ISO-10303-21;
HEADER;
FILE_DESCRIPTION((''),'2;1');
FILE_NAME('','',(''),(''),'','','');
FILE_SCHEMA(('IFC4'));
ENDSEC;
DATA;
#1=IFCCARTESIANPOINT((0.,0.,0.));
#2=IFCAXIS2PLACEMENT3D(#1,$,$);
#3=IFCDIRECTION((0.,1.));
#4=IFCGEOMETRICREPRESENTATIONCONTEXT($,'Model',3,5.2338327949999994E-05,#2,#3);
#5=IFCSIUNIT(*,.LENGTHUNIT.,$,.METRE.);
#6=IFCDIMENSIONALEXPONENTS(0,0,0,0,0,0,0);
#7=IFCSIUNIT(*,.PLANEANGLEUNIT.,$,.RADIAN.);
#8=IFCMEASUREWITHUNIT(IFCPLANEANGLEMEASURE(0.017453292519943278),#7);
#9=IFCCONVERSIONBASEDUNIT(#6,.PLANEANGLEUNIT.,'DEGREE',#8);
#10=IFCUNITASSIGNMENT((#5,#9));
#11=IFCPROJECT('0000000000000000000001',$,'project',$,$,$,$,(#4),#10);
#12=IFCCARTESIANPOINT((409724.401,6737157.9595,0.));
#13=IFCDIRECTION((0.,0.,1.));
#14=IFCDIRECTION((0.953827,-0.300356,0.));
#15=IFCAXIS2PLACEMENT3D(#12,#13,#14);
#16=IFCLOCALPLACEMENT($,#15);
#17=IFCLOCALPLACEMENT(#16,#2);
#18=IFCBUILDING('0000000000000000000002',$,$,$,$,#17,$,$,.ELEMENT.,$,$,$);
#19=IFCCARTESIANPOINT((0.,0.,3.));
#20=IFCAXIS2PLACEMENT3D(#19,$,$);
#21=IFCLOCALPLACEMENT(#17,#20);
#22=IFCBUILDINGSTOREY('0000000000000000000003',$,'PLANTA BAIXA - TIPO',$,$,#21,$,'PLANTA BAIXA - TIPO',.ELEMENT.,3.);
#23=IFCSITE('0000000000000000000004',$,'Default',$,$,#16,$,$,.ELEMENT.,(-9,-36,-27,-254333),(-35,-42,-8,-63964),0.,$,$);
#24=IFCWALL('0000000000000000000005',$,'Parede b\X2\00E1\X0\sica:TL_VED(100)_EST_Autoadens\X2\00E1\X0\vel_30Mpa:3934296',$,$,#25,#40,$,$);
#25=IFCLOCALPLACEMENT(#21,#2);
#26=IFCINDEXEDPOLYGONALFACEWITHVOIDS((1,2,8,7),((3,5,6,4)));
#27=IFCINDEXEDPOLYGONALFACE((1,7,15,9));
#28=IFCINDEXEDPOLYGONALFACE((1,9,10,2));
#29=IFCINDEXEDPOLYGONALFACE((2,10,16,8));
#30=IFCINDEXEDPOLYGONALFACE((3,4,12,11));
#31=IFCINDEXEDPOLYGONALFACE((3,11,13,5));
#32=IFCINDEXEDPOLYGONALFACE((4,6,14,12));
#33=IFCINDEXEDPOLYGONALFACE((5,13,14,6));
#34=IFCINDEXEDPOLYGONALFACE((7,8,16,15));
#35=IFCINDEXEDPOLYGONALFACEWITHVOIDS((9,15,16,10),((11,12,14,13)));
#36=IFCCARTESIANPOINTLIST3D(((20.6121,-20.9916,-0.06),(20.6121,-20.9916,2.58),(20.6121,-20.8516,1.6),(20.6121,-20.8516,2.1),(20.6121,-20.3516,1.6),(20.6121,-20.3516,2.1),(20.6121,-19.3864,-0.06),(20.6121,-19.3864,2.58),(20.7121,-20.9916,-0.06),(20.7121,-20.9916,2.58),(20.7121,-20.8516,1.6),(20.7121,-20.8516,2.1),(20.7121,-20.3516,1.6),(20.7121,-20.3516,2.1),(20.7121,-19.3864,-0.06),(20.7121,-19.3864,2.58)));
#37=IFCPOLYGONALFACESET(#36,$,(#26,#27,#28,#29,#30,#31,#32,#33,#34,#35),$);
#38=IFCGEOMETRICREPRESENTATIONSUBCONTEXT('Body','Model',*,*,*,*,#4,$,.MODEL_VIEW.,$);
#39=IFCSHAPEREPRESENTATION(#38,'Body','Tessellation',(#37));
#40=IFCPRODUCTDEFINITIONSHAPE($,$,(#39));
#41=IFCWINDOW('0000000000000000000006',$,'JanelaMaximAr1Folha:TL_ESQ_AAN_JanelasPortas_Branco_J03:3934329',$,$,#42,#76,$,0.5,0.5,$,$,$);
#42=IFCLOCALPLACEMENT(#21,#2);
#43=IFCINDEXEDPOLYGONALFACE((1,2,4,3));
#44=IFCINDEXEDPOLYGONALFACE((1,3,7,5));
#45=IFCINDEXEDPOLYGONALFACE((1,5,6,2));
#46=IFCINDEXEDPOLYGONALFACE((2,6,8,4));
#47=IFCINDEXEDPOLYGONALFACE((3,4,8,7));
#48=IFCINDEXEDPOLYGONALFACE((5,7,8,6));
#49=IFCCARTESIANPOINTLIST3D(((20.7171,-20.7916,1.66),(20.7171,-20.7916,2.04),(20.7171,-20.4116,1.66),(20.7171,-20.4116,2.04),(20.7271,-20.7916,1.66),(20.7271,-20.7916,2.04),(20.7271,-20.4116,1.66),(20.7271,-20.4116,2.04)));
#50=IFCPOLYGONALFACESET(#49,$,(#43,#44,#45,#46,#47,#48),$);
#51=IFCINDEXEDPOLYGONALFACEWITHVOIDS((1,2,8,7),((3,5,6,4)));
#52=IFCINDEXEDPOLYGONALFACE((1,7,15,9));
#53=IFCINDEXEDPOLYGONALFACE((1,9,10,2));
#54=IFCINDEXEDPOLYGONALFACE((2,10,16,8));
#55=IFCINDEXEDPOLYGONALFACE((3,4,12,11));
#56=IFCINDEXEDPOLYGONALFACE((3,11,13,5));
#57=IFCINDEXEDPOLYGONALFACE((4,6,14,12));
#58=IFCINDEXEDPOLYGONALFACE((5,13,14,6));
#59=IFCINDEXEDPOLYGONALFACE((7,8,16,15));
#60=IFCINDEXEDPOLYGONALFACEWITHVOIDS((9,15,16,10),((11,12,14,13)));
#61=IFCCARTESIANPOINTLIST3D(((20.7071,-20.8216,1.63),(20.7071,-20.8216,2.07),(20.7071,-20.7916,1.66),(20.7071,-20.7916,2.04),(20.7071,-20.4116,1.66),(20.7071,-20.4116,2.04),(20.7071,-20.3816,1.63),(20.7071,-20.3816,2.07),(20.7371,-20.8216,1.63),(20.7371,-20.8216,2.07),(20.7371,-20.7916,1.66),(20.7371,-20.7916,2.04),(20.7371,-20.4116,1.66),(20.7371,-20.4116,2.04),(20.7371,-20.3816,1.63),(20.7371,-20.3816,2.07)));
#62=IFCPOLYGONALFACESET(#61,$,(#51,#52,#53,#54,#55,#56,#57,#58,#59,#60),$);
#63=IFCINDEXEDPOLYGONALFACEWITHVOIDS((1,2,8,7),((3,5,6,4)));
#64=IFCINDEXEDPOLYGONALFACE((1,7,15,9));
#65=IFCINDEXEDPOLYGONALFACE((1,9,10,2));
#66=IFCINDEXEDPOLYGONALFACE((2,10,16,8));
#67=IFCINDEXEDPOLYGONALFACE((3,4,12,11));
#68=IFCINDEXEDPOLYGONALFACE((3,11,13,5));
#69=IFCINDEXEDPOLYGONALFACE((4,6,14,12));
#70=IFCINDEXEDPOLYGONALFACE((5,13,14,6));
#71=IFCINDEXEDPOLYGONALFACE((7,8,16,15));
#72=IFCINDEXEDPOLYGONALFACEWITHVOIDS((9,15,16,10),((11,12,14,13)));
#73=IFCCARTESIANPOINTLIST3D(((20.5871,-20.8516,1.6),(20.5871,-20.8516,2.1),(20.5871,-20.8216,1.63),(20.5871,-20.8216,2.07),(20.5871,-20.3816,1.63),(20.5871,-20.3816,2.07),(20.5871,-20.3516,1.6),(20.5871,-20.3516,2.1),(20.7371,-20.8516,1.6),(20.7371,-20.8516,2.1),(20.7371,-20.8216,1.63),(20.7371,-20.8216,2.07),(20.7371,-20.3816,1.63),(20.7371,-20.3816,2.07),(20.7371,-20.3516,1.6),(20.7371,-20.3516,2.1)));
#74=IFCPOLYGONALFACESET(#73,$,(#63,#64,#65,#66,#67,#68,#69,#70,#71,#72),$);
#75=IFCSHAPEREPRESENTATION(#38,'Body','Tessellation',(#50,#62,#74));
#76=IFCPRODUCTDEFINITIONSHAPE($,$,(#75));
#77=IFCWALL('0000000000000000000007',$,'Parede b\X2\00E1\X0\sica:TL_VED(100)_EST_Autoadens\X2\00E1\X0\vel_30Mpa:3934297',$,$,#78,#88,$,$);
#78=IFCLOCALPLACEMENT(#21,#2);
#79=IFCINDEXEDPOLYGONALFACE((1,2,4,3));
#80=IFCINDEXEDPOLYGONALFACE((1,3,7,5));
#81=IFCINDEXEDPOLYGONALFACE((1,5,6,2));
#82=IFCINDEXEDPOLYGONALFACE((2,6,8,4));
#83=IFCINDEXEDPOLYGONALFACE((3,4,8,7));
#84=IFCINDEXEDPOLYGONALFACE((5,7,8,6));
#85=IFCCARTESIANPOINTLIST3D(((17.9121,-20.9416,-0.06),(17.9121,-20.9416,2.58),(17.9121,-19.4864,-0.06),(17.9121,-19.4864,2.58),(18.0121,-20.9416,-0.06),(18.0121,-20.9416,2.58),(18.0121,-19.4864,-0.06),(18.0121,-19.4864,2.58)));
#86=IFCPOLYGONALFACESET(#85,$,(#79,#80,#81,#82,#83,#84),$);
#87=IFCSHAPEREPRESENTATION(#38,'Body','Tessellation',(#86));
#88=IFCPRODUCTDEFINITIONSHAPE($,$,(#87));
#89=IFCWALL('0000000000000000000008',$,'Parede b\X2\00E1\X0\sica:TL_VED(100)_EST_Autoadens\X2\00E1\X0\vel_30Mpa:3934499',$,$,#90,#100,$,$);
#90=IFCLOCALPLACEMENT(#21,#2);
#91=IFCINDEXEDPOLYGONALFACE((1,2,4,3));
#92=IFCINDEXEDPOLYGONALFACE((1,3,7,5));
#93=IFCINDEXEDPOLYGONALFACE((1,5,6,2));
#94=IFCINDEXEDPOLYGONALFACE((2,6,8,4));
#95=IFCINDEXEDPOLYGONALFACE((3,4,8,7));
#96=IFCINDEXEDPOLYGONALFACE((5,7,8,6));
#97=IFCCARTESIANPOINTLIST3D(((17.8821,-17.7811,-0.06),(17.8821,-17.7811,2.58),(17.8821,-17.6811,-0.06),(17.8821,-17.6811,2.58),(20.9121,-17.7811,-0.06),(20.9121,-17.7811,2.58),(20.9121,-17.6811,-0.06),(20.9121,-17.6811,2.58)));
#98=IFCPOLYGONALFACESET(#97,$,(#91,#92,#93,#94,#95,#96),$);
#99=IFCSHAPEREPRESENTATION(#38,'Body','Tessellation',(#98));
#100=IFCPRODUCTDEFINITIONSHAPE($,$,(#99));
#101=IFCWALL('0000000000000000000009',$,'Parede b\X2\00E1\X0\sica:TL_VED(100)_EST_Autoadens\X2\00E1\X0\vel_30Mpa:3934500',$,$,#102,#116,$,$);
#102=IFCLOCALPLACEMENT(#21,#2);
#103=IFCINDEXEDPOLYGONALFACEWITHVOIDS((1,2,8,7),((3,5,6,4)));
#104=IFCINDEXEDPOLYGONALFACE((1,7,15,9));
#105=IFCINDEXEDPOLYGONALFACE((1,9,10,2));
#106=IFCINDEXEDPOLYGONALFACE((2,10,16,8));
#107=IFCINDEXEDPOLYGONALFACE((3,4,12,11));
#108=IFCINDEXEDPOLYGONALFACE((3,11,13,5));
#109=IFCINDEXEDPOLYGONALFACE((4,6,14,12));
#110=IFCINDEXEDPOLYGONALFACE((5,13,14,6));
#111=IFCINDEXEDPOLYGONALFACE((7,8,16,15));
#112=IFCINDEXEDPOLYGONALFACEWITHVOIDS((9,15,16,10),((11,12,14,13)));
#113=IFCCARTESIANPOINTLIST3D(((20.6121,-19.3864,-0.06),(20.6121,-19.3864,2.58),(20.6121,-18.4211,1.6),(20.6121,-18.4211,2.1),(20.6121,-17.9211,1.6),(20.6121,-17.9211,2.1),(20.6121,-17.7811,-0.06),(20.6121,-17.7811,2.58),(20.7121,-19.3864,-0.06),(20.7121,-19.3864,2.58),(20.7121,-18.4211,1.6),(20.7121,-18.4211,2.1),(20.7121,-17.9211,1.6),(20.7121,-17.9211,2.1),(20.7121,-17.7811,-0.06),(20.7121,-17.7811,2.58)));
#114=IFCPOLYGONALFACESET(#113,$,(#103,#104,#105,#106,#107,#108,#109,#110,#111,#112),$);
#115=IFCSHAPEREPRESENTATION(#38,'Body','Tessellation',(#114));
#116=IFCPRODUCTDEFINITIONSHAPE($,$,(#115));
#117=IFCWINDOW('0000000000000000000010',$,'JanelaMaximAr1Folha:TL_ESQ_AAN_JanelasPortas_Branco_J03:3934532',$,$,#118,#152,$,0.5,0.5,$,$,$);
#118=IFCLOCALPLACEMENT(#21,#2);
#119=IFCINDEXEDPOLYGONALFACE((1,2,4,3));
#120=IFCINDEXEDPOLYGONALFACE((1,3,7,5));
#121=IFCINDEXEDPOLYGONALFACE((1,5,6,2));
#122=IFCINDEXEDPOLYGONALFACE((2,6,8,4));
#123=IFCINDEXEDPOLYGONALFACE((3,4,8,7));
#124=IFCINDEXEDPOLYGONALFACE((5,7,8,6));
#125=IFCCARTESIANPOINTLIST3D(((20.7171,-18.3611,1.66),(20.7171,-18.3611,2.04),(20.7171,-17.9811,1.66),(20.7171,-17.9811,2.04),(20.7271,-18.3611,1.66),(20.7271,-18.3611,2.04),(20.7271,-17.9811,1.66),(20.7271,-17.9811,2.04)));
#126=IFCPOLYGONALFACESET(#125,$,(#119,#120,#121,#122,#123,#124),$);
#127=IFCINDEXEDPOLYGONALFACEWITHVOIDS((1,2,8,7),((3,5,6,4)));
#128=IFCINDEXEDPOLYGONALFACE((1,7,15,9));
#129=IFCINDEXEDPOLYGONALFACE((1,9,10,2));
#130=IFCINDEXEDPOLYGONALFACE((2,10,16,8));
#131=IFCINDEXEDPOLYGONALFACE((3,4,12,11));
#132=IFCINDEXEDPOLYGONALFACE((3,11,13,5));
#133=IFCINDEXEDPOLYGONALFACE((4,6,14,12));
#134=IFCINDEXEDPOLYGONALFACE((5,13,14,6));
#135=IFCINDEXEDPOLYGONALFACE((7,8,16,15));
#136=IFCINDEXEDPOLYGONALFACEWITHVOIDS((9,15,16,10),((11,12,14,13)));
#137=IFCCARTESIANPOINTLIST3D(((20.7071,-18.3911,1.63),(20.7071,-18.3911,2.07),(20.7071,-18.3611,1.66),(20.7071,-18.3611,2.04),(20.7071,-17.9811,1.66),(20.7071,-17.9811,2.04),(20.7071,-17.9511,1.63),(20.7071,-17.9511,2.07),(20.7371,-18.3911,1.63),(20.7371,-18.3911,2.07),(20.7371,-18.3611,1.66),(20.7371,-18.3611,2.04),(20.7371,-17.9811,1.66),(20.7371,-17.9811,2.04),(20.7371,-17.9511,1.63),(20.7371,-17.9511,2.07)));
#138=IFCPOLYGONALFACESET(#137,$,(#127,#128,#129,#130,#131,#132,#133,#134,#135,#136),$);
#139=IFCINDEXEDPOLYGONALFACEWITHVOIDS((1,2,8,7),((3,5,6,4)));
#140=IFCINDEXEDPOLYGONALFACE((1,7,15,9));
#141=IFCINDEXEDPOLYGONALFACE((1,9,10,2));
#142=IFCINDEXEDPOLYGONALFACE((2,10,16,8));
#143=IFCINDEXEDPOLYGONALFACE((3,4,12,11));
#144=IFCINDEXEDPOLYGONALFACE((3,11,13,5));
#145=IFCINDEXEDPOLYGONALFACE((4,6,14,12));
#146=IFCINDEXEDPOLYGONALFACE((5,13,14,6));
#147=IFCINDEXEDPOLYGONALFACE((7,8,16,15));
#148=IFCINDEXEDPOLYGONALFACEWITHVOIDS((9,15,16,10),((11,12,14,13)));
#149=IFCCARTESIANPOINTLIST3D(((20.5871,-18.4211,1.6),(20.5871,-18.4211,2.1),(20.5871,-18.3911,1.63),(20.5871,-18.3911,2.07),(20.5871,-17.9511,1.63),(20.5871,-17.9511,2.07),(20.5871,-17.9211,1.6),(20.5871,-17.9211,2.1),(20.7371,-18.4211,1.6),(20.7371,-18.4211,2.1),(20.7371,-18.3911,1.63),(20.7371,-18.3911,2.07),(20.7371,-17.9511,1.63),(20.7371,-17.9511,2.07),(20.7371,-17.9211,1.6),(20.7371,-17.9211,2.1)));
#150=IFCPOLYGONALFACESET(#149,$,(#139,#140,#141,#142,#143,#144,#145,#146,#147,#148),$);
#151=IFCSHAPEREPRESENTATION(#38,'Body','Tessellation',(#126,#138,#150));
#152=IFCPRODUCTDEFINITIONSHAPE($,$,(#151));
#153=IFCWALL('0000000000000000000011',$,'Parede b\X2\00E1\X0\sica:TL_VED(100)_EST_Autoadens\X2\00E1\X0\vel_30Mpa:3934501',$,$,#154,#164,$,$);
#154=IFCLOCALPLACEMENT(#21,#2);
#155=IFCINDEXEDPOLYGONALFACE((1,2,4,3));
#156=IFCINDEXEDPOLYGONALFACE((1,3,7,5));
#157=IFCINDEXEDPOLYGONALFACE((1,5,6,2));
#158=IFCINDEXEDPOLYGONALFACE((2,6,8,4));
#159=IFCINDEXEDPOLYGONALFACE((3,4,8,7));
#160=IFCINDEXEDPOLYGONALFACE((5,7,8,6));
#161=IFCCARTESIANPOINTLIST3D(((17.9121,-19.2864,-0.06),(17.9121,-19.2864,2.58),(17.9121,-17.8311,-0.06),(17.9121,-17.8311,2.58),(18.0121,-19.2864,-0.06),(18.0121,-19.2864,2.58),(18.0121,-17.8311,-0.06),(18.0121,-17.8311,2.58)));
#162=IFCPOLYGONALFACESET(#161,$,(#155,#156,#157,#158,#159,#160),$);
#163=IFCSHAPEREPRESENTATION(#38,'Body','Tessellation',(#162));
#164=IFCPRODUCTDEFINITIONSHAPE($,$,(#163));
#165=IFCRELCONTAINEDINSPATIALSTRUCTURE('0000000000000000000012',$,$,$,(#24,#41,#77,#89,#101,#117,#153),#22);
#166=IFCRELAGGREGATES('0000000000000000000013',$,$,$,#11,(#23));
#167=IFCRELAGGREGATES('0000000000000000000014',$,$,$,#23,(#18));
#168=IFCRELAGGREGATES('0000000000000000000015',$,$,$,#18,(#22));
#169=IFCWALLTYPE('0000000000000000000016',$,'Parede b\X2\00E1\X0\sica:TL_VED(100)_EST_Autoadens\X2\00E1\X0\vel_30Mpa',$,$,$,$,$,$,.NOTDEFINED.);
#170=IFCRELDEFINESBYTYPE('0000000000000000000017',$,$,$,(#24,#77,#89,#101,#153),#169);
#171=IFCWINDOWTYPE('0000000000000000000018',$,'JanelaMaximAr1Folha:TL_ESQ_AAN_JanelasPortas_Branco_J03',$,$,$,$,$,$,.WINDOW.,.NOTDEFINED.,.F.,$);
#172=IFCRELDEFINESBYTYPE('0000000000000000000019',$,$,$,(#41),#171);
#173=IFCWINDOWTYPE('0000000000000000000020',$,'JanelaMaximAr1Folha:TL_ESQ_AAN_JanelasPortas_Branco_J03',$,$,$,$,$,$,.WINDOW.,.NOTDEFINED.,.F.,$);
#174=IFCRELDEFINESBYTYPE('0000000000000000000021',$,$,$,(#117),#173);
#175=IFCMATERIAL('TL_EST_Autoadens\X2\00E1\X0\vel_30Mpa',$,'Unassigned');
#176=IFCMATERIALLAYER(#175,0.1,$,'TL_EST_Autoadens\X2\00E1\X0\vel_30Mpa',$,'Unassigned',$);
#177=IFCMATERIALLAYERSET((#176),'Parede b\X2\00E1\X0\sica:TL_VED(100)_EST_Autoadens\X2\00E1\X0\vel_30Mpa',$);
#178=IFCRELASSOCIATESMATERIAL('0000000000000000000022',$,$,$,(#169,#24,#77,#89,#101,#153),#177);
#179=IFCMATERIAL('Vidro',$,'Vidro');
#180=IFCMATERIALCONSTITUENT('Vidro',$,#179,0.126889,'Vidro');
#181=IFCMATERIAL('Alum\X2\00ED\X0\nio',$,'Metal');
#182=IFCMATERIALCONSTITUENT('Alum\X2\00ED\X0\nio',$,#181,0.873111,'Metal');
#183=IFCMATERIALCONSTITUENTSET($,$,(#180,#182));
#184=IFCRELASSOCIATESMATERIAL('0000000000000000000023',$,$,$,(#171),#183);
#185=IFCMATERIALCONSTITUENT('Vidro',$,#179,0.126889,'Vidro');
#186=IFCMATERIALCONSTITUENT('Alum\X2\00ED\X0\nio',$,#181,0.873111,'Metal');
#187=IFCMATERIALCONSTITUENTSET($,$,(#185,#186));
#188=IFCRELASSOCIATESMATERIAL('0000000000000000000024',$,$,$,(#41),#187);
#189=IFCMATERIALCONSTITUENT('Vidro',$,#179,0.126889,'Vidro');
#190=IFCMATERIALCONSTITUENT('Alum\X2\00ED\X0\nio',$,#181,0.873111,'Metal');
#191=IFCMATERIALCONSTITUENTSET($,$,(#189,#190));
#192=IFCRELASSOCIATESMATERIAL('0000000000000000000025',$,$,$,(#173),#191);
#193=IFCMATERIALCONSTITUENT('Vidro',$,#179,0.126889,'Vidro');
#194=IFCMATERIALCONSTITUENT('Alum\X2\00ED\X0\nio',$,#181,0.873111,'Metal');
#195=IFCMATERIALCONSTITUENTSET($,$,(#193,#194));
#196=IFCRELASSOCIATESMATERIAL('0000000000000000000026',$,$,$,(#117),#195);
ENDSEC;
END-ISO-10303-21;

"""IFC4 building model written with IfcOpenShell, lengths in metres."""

from ifc_helpers import new_model, entity, si_unit, converted_unit, direction, frame, frame_2d, origin, place, context, subcontext, project, spatial, polyline, rectangle, outline, extrude, source, transform, mapped, material, layer, layer_set, layer_usage, constituent, constituent_set, type_object, type_shapes, element, fill, save


model = new_model("IFC4")

# Units and contexts
model_context = context("Model", 3, precision=5.2338327949999994e-05, world=origin(), true_north=direction((0.0, 1.0)))
body_context = subcontext(model_context, "Body", "Model", "MODEL_VIEW")
ifc_project = project(units=[si_unit("LENGTHUNIT", "METRE"), converted_unit("PLANEANGLEUNIT", "DEGREE", entity("IfcPlaneAngleMeasure", 0.017453292519943278), si_unit("PLANEANGLEUNIT", "RADIAN"), dimensions=[0, 0, 0, 0, 0, 0, 0])], contexts=[model_context])

# Site, building, storey
site_placement = place(None, frame((409724.401, 6737157.9595, 0.0), z_axis=(0.0, 0.0, 1.0), x_axis=(0.953827, -0.300356, 0.0)))
site = spatial("IfcSite", under=ifc_project, at=site_placement, Name="Default", CompositionType="ELEMENT", RefLatitude=(-9, -36, -27, -254333), RefLongitude=(-35, -42, -8, -63964), RefElevation=0.0)
building_placement = place(site_placement, origin())
building = spatial("IfcBuilding", under=site, at=building_placement, CompositionType="ELEMENT")
storey_placement = place(building_placement, frame((0.0, 0.0, 3.0)))
storey = spatial("IfcBuildingStorey", under=building, at=storey_placement, Name="PLANTA BAIXA - TIPO", LongName="PLANTA BAIXA - TIPO", CompositionType="ELEMENT", Elevation=3.0)

# Wall, opening, window
ifc_material_1 = material(Name="TL_EST_Autoadensável_30Mpa", Category="Unassigned")
ifc_layer_1 = layer(ifc_material_1, 0.1, Name="TL_EST_Autoadensável_30Mpa", Category="Unassigned")
ifc_layer_set_1 = layer_set([ifc_layer_1], Name="Parede básica:TL_VED(100)_EST_Autoadensável_30Mpa")
ifc_layer_usage_1 = layer_usage(ifc_layer_set_1, "AXIS2", "NEGATIVE", 0.05)
wall_type_1 = type_object("IfcWallType", Name="Parede básica:TL_VED(100)_EST_Autoadensável_30Mpa", PredefinedType="NOTDEFINED", material=ifc_layer_set_1)
wall_1_placement = place(storey_placement, frame((20.6621, -19.3864, -0.06), z_axis=(0.0, 0.0, 1.0), x_axis=(0.0, -1.0, 0.0)))
wall_1 = element("IfcWall", 1, at=wall_1_placement, inside=storey, type_object=wall_type_1, material=ifc_layer_usage_1, Name="Parede básica:TL_VED(100)_EST_Autoadensável_30Mpa:3934296", context=body_context, shape_type="SweptSolid", body=[
    extrude(rectangle(XDim=1.6052, YDim=0.1, at=frame_2d((0.8026, 0.0), x_axis=(-1.0, 0.0))), origin(), (0.0, 0.0, 1.0), 2.64),
])
opening_1_placement = place(wall_1_placement, frame((1.4652, 0.05, 1.66)))
opening_1 = element("IfcOpeningElement", 2, at=opening_1_placement, cuts=wall_1, PredefinedType="OPENING", context=body_context, shape_type="SweptSolid", body=[
    extrude(rectangle(XDim=0.5, YDim=0.5, at=frame_2d((0.25, 0.25), x_axis=(1.0, 0.0))), frame((0.0, 0.0, 0.0), z_axis=(0.0, -1.0, 0.0), x_axis=(0.0, 0.0, 1.0)), (0.0, 0.0, 1.0), 0.1),
])
ifc_material_2 = material(Name="Vidro", Category="Vidro")
ifc_constituent_1 = constituent(ifc_material_2, Name="Vidro", Category="Vidro", fraction=0.126889)
ifc_material_3 = material(Name="Alumínio", Category="Metal")
ifc_constituent_2 = constituent(ifc_material_3, Name="Alumínio", Category="Metal", fraction=0.873111)
ifc_constituent_set_1 = constituent_set(constituents=[ifc_constituent_1, ifc_constituent_2])
ifc_constituent_3 = constituent(ifc_material_2, Name="Vidro", Category="Vidro", fraction=0.126889)
ifc_constituent_4 = constituent(ifc_material_3, Name="Alumínio", Category="Metal", fraction=0.873111)
ifc_constituent_set_2 = constituent_set(constituents=[ifc_constituent_3, ifc_constituent_4])
window_type_1 = type_object("IfcWindowType", Name="JanelaMaximAr1Folha:TL_ESQ_AAN_JanelasPortas_Branco_J03", ParameterTakesPrecedence=False, PartitioningType="NOTDEFINED", PredefinedType="WINDOW", material=ifc_constituent_set_2)
shared_shape_1 = source(origin(), body_context, "Body", "SweptSolid", [
    extrude(rectangle(XDim=0.01, YDim=0.38, at=frame_2d((0.0, 0.0), x_axis=(1.0, 0.0))), frame((0.25, -0.01, 0.06), z_axis=(0.0, 0.0, 1.0), x_axis=(0.0, 1.0, 0.0)), (0.0, 0.0, 1.0), 0.38),
    extrude(outline(polyline([(-0.22, -0.22), (0.22, -0.22), (0.22, 0.22), (-0.22, 0.22), (-0.22, -0.22)]), holes=[polyline([(0.19, 0.19), (0.19, -0.19), (-0.19, -0.19), (-0.19, 0.19), (0.19, 0.19)])]), frame((0.25, -0.025, 0.25), z_axis=(0.0, 1.0, 0.0), x_axis=(0.0, 0.0, -1.0)), (0.0, 0.0, 1.0), 0.03),
    extrude(outline(polyline([(-0.25, -0.25), (0.25, -0.25), (0.25, 0.25), (-0.25, 0.25), (-0.25, -0.25)]), holes=[polyline([(-0.22, -0.22), (-0.22, 0.22), (0.22, 0.22), (0.22, -0.22), (-0.22, -0.22)])]), frame((0.25, -0.025, 0.25), z_axis=(0.0, 1.0, 0.0), x_axis=(0.0, 0.0, -1.0)), (0.0, 0.0, 1.0), 0.15),
])
type_shapes(window_type_1, [shared_shape_1])
window_1_placement = place(opening_1_placement, frame((0.0, 0.0, 0.0), z_axis=(0.0, 0.0, 1.0), x_axis=(-1.0, 0.0, 0.0)))
window_1 = element("IfcWindow", 3, at=window_1_placement, inside=storey, type_object=window_type_1, material=ifc_constituent_set_1, Name="JanelaMaximAr1Folha:TL_ESQ_AAN_JanelasPortas_Branco_J03:3934329", OverallHeight=0.5, OverallWidth=0.5, context=body_context, shape_type="MappedRepresentation", body=[
    mapped(shared_shape_1, transform((0.0, 0.0, 0.0), scale=1.0)),
])
fill(opening_1, window_1)

# Walls
ifc_layer_usage_2 = layer_usage(ifc_layer_set_1, "AXIS2", "POSITIVE", -0.05)
wall_2_placement = place(storey_placement, frame((17.9621, -19.4864, -0.06), z_axis=(0.0, 0.0, 1.0), x_axis=(0.0, -1.0, 0.0)))
element("IfcWall", 4, at=wall_2_placement, inside=storey, type_object=wall_type_1, material=ifc_layer_usage_2, Name="Parede básica:TL_VED(100)_EST_Autoadensável_30Mpa:3934297", context=body_context, shape_type="SweptSolid", body=[
    extrude(rectangle(XDim=1.4552, YDim=0.1, at=frame_2d((0.7276, 0.0), x_axis=(-1.0, 0.0))), origin(), (0.0, 0.0, 1.0), 2.64),
])
ifc_layer_usage_3 = layer_usage(ifc_layer_set_1, "AXIS2", "POSITIVE", -0.05)
wall_3_placement = place(storey_placement, frame((17.8821, -17.7311, -0.06)))
element("IfcWall", 5, at=wall_3_placement, inside=storey, type_object=wall_type_1, material=ifc_layer_usage_3, Name="Parede básica:TL_VED(100)_EST_Autoadensável_30Mpa:3934499", context=body_context, shape_type="SweptSolid", body=[
    extrude(rectangle(XDim=3.03, YDim=0.1, at=frame_2d((1.515, 0.0), x_axis=(-1.0, 0.0))), origin(), (0.0, 0.0, 1.0), 2.64),
])

# Wall, opening, window
ifc_layer_usage_4 = layer_usage(ifc_layer_set_1, "AXIS2", "POSITIVE", -0.05)
wall_4_placement = place(storey_placement, frame((20.6621, -19.3864, -0.06), z_axis=(0.0, 0.0, 1.0), x_axis=(0.0, 1.0, 0.0)))
wall_4 = element("IfcWall", 6, at=wall_4_placement, inside=storey, type_object=wall_type_1, material=ifc_layer_usage_4, Name="Parede básica:TL_VED(100)_EST_Autoadensável_30Mpa:3934500", context=body_context, shape_type="SweptSolid", body=[
    extrude(rectangle(XDim=1.6052, YDim=0.1, at=frame_2d((0.8026, 0.0), x_axis=(-1.0, 0.0))), origin(), (0.0, 0.0, 1.0), 2.64),
])
opening_2_placement = place(wall_4_placement, frame((0.9652, -0.05, 1.66)))
opening_2 = element("IfcOpeningElement", 7, at=opening_2_placement, cuts=wall_4, PredefinedType="OPENING", context=body_context, shape_type="SweptSolid", body=[
    extrude(rectangle(XDim=0.5, YDim=0.5, at=frame_2d((0.25, 0.25), x_axis=(1.0, 0.0))), frame((0.0, 0.0, 0.0), z_axis=(0.0, 1.0, 0.0), x_axis=(0.0, 0.0, 1.0)), (0.0, 0.0, 1.0), 0.1),
])
ifc_constituent_5 = constituent(ifc_material_2, Name="Vidro", Category="Vidro", fraction=0.126889)
ifc_constituent_6 = constituent(ifc_material_3, Name="Alumínio", Category="Metal", fraction=0.873111)
ifc_constituent_set_3 = constituent_set(constituents=[ifc_constituent_5, ifc_constituent_6])
ifc_constituent_7 = constituent(ifc_material_2, Name="Vidro", Category="Vidro", fraction=0.126889)
ifc_constituent_8 = constituent(ifc_material_3, Name="Alumínio", Category="Metal", fraction=0.873111)
ifc_constituent_set_4 = constituent_set(constituents=[ifc_constituent_7, ifc_constituent_8])
window_type_2 = type_object("IfcWindowType", Name="JanelaMaximAr1Folha:TL_ESQ_AAN_JanelasPortas_Branco_J03", ParameterTakesPrecedence=False, PartitioningType="NOTDEFINED", PredefinedType="WINDOW", material=ifc_constituent_set_4)
shared_shape_2 = source(origin(), body_context, "Body", "SweptSolid", [
    extrude(rectangle(XDim=0.38, YDim=0.01, at=frame_2d((0.0, 0.0), x_axis=(1.0, 0.0))), frame((0.25, -0.01, 0.06)), (0.0, 0.0, 1.0), 0.38),
    extrude(outline(polyline([(-0.22, -0.22), (0.22, -0.22), (0.22, 0.22), (-0.22, 0.22), (-0.22, -0.22)]), holes=[polyline([(0.19, 0.19), (0.19, -0.19), (-0.19, -0.19), (-0.19, 0.19), (0.19, 0.19)])]), frame((0.25, 0.005, 0.25), z_axis=(0.0, -1.0, 0.0), x_axis=(0.0, 0.0, -1.0)), (0.0, 0.0, 1.0), 0.03),
    extrude(outline(polyline([(-0.25, -0.25), (0.25, -0.25), (0.25, 0.25), (-0.25, 0.25), (-0.25, -0.25)]), holes=[polyline([(-0.22, -0.22), (-0.22, 0.22), (0.22, 0.22), (0.22, -0.22), (-0.22, -0.22)])]), frame((0.25, 0.125, 0.25), z_axis=(0.0, -1.0, 0.0), x_axis=(0.0, 0.0, -1.0)), (0.0, 0.0, 1.0), 0.15),
])
type_shapes(window_type_2, [shared_shape_2])
window_2_placement = place(opening_2_placement, origin())
window_2 = element("IfcWindow", 8, at=window_2_placement, inside=storey, type_object=window_type_2, material=ifc_constituent_set_3, Name="JanelaMaximAr1Folha:TL_ESQ_AAN_JanelasPortas_Branco_J03:3934532", OverallHeight=0.5, OverallWidth=0.5, context=body_context, shape_type="MappedRepresentation", body=[
    mapped(shared_shape_2, transform((0.0, 0.0, 0.0), scale=1.0)),
])
fill(opening_2, window_2)

# Wall
ifc_layer_usage_5 = layer_usage(ifc_layer_set_1, "AXIS2", "NEGATIVE", 0.05)
wall_5_placement = place(storey_placement, frame((17.9621, -19.2864, -0.06), z_axis=(0.0, 0.0, 1.0), x_axis=(0.0, 1.0, 0.0)))
element("IfcWall", 9, at=wall_5_placement, inside=storey, type_object=wall_type_1, material=ifc_layer_usage_5, Name="Parede básica:TL_VED(100)_EST_Autoadensável_30Mpa:3934501", context=body_context, shape_type="SweptSolid", body=[
    extrude(rectangle(XDim=1.4552, YDim=0.1, at=frame_2d((0.7276, 0.0), x_axis=(-1.0, 0.0))), origin(), (0.0, 0.0, 1.0), 2.64),
])

save(model, "model.ifc")
